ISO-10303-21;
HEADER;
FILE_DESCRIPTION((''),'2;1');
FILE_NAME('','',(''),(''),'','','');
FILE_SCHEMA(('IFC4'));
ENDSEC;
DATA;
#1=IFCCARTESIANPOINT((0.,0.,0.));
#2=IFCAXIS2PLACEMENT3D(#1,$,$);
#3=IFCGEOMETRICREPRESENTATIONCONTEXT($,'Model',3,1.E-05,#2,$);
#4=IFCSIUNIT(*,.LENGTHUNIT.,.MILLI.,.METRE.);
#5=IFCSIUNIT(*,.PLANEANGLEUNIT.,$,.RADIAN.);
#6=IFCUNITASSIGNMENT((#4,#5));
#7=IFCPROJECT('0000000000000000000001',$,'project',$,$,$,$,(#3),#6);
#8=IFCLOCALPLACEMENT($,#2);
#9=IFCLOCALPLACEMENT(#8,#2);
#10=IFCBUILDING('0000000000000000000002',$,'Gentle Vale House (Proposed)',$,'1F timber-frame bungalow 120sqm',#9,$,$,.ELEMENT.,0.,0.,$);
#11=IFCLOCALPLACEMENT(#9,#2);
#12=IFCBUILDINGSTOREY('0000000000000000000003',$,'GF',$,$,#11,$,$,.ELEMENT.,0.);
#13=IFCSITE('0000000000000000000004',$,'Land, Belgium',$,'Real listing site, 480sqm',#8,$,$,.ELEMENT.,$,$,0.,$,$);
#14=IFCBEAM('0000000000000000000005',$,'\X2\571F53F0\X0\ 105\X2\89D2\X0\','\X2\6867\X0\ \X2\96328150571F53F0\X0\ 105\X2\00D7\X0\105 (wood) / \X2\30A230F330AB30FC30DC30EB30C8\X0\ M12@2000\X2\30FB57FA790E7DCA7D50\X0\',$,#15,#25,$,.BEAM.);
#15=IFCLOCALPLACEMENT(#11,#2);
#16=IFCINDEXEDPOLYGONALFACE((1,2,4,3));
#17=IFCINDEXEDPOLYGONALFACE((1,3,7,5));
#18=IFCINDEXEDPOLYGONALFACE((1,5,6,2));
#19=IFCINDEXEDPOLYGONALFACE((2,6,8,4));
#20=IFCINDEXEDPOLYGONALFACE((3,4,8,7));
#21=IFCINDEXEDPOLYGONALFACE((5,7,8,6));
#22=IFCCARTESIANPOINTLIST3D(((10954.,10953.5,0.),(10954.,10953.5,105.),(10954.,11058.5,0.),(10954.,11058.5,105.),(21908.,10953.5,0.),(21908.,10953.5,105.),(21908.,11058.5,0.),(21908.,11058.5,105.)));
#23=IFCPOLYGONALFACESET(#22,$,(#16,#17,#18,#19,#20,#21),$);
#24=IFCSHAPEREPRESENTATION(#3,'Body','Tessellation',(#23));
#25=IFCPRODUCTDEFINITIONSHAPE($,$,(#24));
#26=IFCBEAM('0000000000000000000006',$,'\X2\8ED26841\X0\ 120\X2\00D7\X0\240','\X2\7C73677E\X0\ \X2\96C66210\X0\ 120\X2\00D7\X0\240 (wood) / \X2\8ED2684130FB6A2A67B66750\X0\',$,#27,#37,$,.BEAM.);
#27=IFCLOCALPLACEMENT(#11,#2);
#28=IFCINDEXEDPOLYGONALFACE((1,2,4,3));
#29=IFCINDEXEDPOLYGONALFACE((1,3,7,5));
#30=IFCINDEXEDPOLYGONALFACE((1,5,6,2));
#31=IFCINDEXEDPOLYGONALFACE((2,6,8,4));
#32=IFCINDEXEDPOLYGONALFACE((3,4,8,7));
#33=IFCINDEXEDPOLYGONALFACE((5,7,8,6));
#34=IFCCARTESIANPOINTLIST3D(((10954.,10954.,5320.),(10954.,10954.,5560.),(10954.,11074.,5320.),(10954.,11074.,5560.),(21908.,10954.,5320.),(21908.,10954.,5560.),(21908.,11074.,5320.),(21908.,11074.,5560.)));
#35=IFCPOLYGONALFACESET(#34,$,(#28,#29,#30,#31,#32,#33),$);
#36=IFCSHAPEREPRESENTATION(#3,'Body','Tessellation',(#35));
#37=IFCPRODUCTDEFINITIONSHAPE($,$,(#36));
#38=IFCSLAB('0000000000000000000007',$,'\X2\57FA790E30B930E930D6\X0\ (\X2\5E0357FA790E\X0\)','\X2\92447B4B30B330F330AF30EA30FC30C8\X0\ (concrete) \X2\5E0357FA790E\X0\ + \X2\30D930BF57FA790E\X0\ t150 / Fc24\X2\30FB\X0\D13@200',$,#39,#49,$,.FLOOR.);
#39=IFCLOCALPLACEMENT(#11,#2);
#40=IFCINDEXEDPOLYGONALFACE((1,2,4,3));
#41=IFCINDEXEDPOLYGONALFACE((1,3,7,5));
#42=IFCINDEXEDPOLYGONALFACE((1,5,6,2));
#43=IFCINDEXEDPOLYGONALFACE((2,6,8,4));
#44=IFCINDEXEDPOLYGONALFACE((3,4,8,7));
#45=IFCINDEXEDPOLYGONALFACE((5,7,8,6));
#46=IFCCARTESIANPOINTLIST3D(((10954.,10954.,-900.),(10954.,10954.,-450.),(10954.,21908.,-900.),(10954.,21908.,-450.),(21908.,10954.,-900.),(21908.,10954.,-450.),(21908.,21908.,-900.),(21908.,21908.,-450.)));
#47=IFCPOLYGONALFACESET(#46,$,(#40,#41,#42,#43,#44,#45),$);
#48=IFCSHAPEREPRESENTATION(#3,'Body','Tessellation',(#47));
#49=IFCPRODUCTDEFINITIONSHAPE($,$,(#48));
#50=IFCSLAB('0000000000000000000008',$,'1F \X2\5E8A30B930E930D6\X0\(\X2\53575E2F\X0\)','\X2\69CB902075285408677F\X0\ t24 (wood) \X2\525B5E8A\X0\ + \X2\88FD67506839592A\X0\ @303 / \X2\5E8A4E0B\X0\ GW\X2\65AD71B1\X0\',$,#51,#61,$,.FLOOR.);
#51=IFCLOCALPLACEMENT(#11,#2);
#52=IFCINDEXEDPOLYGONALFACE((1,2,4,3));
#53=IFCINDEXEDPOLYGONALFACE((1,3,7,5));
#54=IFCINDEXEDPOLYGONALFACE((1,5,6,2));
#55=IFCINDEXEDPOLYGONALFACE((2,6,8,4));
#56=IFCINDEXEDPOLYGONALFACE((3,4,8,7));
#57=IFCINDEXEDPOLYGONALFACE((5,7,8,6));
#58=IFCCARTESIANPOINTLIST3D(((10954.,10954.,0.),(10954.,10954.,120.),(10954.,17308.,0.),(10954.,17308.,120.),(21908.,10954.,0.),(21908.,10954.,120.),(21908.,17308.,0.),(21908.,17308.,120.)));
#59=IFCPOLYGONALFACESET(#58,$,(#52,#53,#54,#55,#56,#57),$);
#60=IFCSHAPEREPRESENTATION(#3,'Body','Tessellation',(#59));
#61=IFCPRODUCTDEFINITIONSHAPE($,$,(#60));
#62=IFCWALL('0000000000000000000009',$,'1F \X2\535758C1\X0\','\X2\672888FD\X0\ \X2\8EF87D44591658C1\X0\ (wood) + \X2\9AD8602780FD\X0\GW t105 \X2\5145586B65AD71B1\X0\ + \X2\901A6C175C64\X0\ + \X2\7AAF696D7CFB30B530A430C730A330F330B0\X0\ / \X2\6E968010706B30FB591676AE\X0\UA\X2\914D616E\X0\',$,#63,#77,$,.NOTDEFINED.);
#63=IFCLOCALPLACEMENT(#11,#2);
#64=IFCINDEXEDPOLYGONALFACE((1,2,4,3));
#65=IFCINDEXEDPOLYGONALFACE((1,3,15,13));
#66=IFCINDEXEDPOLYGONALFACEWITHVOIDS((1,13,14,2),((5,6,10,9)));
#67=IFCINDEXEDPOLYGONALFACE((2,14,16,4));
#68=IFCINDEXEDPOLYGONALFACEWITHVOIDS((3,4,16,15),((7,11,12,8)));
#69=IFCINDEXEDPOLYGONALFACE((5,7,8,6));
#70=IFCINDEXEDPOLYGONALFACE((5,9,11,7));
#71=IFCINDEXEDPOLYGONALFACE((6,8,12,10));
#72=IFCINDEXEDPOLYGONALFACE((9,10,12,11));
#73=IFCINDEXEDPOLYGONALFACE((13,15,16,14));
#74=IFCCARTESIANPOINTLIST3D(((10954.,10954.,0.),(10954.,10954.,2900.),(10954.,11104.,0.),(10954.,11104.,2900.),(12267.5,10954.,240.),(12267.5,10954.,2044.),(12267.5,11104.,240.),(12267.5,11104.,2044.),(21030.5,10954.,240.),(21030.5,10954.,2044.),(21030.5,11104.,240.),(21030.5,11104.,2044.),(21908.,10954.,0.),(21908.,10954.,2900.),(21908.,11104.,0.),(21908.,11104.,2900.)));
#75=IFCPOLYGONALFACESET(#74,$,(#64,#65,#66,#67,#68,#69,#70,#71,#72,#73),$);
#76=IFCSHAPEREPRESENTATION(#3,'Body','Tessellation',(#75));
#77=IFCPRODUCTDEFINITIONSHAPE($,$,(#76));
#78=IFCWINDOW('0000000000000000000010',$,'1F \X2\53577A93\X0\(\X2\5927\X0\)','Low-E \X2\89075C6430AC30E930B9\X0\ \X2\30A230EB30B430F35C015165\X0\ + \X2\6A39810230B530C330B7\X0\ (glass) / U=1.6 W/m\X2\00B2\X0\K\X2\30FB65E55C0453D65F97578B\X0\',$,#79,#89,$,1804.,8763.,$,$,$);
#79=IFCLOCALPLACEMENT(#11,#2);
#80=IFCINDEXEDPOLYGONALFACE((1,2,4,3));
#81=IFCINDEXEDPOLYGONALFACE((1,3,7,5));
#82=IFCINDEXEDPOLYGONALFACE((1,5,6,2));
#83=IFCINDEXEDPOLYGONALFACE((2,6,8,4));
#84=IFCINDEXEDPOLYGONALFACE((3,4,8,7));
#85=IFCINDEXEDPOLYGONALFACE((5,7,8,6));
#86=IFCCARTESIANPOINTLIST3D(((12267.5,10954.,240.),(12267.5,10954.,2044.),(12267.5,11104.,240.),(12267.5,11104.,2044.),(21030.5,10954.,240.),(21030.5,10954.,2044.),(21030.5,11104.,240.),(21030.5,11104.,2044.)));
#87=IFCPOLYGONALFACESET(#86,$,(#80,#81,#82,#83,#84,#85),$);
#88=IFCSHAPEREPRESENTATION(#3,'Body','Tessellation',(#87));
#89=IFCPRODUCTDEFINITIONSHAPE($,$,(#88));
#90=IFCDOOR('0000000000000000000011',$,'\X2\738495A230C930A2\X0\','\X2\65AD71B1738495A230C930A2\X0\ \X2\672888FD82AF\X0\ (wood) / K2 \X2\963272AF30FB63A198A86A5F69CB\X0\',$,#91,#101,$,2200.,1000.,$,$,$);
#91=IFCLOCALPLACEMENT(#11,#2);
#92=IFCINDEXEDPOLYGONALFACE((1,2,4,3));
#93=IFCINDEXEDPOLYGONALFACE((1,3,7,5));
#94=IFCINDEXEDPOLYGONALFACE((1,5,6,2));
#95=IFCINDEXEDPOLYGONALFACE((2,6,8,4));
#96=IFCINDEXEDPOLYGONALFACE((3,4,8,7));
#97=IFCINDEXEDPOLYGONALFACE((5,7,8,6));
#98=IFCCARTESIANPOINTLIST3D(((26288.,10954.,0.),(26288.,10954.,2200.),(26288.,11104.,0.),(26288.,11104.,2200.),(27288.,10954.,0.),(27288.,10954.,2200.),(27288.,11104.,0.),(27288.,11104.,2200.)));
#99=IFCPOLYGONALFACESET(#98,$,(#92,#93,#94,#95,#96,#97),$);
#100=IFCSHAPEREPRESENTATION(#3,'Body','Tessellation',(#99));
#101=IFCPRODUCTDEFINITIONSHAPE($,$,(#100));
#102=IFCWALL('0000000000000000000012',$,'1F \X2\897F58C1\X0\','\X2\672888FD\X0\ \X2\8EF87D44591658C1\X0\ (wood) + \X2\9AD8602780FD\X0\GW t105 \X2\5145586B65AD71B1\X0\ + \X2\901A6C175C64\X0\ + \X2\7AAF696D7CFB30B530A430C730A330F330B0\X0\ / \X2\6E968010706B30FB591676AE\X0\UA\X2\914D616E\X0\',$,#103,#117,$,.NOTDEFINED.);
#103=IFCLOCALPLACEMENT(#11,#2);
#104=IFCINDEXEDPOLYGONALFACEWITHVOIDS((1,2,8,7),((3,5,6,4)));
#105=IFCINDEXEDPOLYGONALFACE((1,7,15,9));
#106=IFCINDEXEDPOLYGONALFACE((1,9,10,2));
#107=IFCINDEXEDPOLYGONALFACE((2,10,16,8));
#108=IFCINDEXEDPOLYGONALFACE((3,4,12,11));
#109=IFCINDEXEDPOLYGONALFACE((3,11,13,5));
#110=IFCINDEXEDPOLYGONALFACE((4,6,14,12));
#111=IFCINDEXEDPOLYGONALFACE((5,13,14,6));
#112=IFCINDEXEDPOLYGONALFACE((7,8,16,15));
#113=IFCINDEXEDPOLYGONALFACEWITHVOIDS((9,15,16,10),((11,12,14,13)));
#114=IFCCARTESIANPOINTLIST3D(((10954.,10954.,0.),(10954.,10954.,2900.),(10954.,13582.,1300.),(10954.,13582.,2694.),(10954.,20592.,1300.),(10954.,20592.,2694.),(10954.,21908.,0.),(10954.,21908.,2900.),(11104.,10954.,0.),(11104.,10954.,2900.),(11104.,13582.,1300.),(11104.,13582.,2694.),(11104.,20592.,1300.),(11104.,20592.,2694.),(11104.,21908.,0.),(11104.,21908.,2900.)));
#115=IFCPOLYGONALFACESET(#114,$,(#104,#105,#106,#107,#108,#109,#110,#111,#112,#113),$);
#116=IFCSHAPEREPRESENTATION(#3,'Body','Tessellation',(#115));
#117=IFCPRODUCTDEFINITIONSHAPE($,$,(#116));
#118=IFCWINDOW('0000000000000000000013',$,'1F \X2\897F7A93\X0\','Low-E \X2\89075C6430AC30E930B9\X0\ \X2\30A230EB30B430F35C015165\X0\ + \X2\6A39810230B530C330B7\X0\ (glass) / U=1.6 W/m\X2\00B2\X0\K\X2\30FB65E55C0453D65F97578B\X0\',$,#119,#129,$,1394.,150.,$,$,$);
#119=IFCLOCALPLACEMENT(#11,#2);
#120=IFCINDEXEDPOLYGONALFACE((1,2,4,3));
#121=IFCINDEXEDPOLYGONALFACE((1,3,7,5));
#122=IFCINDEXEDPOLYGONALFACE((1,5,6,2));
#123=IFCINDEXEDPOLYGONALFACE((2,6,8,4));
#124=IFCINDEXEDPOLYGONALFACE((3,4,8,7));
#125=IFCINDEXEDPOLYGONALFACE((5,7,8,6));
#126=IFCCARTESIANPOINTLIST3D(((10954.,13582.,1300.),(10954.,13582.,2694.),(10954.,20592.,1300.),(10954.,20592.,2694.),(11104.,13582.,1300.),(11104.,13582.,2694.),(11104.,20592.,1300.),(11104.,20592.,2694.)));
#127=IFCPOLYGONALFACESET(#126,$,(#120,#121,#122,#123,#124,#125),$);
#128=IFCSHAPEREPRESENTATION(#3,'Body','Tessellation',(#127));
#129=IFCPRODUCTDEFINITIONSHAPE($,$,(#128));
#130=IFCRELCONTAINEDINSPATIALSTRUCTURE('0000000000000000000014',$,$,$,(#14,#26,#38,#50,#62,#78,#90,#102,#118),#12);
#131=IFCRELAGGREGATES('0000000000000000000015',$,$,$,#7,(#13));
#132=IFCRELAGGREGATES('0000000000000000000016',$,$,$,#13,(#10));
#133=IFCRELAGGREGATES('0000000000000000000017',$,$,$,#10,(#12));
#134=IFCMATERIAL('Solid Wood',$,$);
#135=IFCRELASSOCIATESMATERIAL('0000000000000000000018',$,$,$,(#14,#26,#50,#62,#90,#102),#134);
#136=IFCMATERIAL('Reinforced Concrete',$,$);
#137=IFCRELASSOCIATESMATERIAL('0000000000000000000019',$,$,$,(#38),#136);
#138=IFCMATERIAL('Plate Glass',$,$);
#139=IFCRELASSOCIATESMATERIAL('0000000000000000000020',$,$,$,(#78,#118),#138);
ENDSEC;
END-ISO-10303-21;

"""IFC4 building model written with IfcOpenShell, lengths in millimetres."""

from ifc_helpers import new_model, si_unit, frame, frame_2d, origin, place, context, project, spatial, rectangle, extrude, material, element, fill, save


model = new_model("IFC4")

# Units and contexts
model_context = context("Model", 3, precision=1e-05, world=origin())
ifc_project = project(units=[si_unit("LENGTHUNIT", "METRE", prefix="MILLI"), si_unit("PLANEANGLEUNIT", "RADIAN")], contexts=[model_context])

# Site, building, storey
site_placement = place(None, origin())
site = spatial("IfcSite", under=ifc_project, at=site_placement, Name="Land, Belgium", ObjectType="Real listing site, 480sqm", CompositionType="ELEMENT", RefElevation=0.0)
building_placement = place(site_placement, origin())
building = spatial("IfcBuilding", under=site, at=building_placement, Name="Gentle Vale House (Proposed)", ObjectType="1F timber-frame bungalow 120sqm", CompositionType="ELEMENT", ElevationOfRefHeight=0.0, ElevationOfTerrain=0.0)
storey_placement = place(building_placement, origin())
storey = spatial("IfcBuildingStorey", under=building, at=storey_placement, Name="GF", CompositionType="ELEMENT", Elevation=0.0)

# Shared definitions
ifc_material_1 = material(Name="Solid Wood")

# Beams
beam_1_placement = place(storey_placement, frame((5477.0, 5477.0, 0.0)))
element("IfcBeam", 1, at=beam_1_placement, inside=storey, material=ifc_material_1, Name="土台 105角", Description="桧 防腐土台 105×105 (wood) / アンカーボルト M12@2000・基礎緊結", PredefinedType="BEAM", context=model_context, shape_type="SweptSolid", body=[
    extrude(rectangle(XDim=10954.0, YDim=105.0, at=frame_2d((5477.0, 52.0))), frame((5477.0, 5477.0, 0.0)), (0.0, 0.0, 1.0), 105.0),
])
beam_2_placement = place(storey_placement, frame((5477.0, 5477.0, 2660.0)))
element("IfcBeam", 2, at=beam_2_placement, inside=storey, material=ifc_material_1, Name="軒桁 120×240", Description="米松 集成 120×240 (wood) / 軒桁・横架材", PredefinedType="BEAM", context=model_context, shape_type="SweptSolid", body=[
    extrude(rectangle(XDim=10954.0, YDim=120.0, at=frame_2d((5477.0, 60.0))), frame((5477.0, 5477.0, 2660.0)), (0.0, 0.0, 1.0), 240.0),
])

# Slabs
ifc_material_2 = material(Name="Reinforced Concrete")
slab_1_placement = place(storey_placement, frame((5477.0, 5477.0, -450.0)))
element("IfcSlab", 3, at=slab_1_placement, inside=storey, material=ifc_material_2, Name="基礎スラブ (布基礎)", Description="鉄筋コンクリート (concrete) 布基礎 + ベタ基礎 t150 / Fc24・D13@200", PredefinedType="FLOOR", context=model_context, shape_type="SweptSolid", body=[
    extrude(rectangle(XDim=10954.0, YDim=10954.0, at=frame_2d((5477.0, 5477.0))), frame((5477.0, 5477.0, -450.0)), (0.0, 0.0, 1.0), 450.0),
])
slab_2_placement = place(storey_placement, frame((5477.0, 5477.0, 0.0)))
element("IfcSlab", 4, at=slab_2_placement, inside=storey, material=ifc_material_1, Name="1F 床スラブ(南帯)", Description="構造用合板 t24 (wood) 剛床 + 製材根太 @303 / 床下 GW断熱", PredefinedType="FLOOR", context=model_context, shape_type="SweptSolid", body=[
    extrude(rectangle(XDim=10954.0, YDim=6354.0, at=frame_2d((5477.0, 3177.0))), frame((5477.0, 5477.0, 0.0)), (0.0, 0.0, 1.0), 120.0),
])

# Wall, openings, window, door
wall_1_placement = place(storey_placement, frame((5477.0, 5477.0, 0.0)))
wall_1 = element("IfcWall", 5, at=wall_1_placement, inside=storey, material=ifc_material_1, Name="1F 南壁", Description="木製 軸組外壁 (wood) + 高性能GW t105 充填断熱 + 通気層 + 窯業系サイディング / 準耐火・外皮UA配慮", PredefinedType="NOTDEFINED", context=model_context, shape_type="SweptSolid", body=[
    extrude(rectangle(XDim=10954.0, YDim=150.0, at=frame_2d((5477.0, 75.0))), frame((5477.0, 5477.0, 0.0)), (0.0, 0.0, 1.0), 2900.0),
])
opening_1_placement = place(storey_placement, frame((6134.0, 5477.0, 120.0)))
opening_1 = element("IfcOpeningElement", 6, at=opening_1_placement, cuts=wall_1, PredefinedType="NOTDEFINED", context=model_context, shape_type="SweptSolid", body=[
    extrude(rectangle(XDim=8763.0, YDim=150.0, at=frame_2d((4381.0, 75.0))), frame((6134.0, 5477.0, 120.0)), (0.0, 0.0, 1.0), 1804.0),
])
opening_2_placement = place(storey_placement, frame((13144.0, 5477.0, 0.0)))
opening_2 = element("IfcOpeningElement", 7, at=opening_2_placement, cuts=wall_1, PredefinedType="NOTDEFINED", context=model_context, shape_type="SweptSolid", body=[
    extrude(rectangle(XDim=1000.0, YDim=150.0, at=frame_2d((500.0, 75.0))), frame((13144.0, 5477.0, 0.0)), (0.0, 0.0, 1.0), 2200.0),
])
ifc_material_3 = material(Name="Plate Glass")
window_1_placement = place(storey_placement, frame((6134.0, 5477.0, 120.0)))
window_1 = element("IfcWindow", 8, at=window_1_placement, inside=storey, material=ifc_material_3, Name="1F 南窓(大)", Description="Low-E 複層ガラス アルゴン封入 + 樹脂サッシ (glass) / U=1.6 W/m²K・日射取得型", OverallHeight=1804.0, OverallWidth=8763.0, context=model_context, shape_type="SweptSolid", body=[
    extrude(rectangle(XDim=8763.0, YDim=150.0, at=frame_2d((4381.0, 75.0))), frame((6134.0, 5477.0, 120.0)), (0.0, 0.0, 1.0), 1804.0),
])
fill(opening_1, window_1)
door_placement = place(storey_placement, frame((13144.0, 5477.0, 0.0)))
door = element("IfcDoor", 9, at=door_placement, inside=storey, material=ifc_material_1, Name="玄関ドア", Description="断熱玄関ドア 木製芯 (wood) / K2 防犯・採風機構", OverallHeight=2200.0, OverallWidth=1000.0, context=model_context, shape_type="SweptSolid", body=[
    extrude(rectangle(XDim=1000.0, YDim=150.0, at=frame_2d((500.0, 75.0))), frame((13144.0, 5477.0, 0.0)), (0.0, 0.0, 1.0), 2200.0),
])
fill(opening_2, door)

# Wall, opening, window
wall_2_placement = place(storey_placement, frame((5477.0, 5477.0, 0.0)))
wall_2 = element("IfcWall", 10, at=wall_2_placement, inside=storey, material=ifc_material_1, Name="1F 西壁", Description="木製 軸組外壁 (wood) + 高性能GW t105 充填断熱 + 通気層 + 窯業系サイディング / 準耐火・外皮UA配慮", PredefinedType="NOTDEFINED", context=model_context, shape_type="SweptSolid", body=[
    extrude(rectangle(XDim=150.0, YDim=10954.0, at=frame_2d((75.0, 5477.0))), frame((5477.0, 5477.0, 0.0)), (0.0, 0.0, 1.0), 2900.0),
])
opening_3_placement = place(storey_placement, frame((5477.0, 6791.0, 650.0)))
opening_3 = element("IfcOpeningElement", 11, at=opening_3_placement, cuts=wall_2, PredefinedType="NOTDEFINED", context=model_context, shape_type="SweptSolid", body=[
    extrude(rectangle(XDim=150.0, YDim=7010.0, at=frame_2d((75.0, 3505.0))), frame((5477.0, 6791.0, 650.0)), (0.0, 0.0, 1.0), 1394.0),
])
window_2_placement = place(storey_placement, frame((5477.0, 6791.0, 650.0)))
window_2 = element("IfcWindow", 12, at=window_2_placement, inside=storey, material=ifc_material_3, Name="1F 西窓", Description="Low-E 複層ガラス アルゴン封入 + 樹脂サッシ (glass) / U=1.6 W/m²K・日射取得型", OverallHeight=1394.0, OverallWidth=150.0, context=model_context, shape_type="SweptSolid", body=[
    extrude(rectangle(XDim=150.0, YDim=7010.0, at=frame_2d((75.0, 3505.0))), frame((5477.0, 6791.0, 650.0)), (0.0, 0.0, 1.0), 1394.0),
])
fill(opening_3, window_2)

save(model, "model.ifc")
